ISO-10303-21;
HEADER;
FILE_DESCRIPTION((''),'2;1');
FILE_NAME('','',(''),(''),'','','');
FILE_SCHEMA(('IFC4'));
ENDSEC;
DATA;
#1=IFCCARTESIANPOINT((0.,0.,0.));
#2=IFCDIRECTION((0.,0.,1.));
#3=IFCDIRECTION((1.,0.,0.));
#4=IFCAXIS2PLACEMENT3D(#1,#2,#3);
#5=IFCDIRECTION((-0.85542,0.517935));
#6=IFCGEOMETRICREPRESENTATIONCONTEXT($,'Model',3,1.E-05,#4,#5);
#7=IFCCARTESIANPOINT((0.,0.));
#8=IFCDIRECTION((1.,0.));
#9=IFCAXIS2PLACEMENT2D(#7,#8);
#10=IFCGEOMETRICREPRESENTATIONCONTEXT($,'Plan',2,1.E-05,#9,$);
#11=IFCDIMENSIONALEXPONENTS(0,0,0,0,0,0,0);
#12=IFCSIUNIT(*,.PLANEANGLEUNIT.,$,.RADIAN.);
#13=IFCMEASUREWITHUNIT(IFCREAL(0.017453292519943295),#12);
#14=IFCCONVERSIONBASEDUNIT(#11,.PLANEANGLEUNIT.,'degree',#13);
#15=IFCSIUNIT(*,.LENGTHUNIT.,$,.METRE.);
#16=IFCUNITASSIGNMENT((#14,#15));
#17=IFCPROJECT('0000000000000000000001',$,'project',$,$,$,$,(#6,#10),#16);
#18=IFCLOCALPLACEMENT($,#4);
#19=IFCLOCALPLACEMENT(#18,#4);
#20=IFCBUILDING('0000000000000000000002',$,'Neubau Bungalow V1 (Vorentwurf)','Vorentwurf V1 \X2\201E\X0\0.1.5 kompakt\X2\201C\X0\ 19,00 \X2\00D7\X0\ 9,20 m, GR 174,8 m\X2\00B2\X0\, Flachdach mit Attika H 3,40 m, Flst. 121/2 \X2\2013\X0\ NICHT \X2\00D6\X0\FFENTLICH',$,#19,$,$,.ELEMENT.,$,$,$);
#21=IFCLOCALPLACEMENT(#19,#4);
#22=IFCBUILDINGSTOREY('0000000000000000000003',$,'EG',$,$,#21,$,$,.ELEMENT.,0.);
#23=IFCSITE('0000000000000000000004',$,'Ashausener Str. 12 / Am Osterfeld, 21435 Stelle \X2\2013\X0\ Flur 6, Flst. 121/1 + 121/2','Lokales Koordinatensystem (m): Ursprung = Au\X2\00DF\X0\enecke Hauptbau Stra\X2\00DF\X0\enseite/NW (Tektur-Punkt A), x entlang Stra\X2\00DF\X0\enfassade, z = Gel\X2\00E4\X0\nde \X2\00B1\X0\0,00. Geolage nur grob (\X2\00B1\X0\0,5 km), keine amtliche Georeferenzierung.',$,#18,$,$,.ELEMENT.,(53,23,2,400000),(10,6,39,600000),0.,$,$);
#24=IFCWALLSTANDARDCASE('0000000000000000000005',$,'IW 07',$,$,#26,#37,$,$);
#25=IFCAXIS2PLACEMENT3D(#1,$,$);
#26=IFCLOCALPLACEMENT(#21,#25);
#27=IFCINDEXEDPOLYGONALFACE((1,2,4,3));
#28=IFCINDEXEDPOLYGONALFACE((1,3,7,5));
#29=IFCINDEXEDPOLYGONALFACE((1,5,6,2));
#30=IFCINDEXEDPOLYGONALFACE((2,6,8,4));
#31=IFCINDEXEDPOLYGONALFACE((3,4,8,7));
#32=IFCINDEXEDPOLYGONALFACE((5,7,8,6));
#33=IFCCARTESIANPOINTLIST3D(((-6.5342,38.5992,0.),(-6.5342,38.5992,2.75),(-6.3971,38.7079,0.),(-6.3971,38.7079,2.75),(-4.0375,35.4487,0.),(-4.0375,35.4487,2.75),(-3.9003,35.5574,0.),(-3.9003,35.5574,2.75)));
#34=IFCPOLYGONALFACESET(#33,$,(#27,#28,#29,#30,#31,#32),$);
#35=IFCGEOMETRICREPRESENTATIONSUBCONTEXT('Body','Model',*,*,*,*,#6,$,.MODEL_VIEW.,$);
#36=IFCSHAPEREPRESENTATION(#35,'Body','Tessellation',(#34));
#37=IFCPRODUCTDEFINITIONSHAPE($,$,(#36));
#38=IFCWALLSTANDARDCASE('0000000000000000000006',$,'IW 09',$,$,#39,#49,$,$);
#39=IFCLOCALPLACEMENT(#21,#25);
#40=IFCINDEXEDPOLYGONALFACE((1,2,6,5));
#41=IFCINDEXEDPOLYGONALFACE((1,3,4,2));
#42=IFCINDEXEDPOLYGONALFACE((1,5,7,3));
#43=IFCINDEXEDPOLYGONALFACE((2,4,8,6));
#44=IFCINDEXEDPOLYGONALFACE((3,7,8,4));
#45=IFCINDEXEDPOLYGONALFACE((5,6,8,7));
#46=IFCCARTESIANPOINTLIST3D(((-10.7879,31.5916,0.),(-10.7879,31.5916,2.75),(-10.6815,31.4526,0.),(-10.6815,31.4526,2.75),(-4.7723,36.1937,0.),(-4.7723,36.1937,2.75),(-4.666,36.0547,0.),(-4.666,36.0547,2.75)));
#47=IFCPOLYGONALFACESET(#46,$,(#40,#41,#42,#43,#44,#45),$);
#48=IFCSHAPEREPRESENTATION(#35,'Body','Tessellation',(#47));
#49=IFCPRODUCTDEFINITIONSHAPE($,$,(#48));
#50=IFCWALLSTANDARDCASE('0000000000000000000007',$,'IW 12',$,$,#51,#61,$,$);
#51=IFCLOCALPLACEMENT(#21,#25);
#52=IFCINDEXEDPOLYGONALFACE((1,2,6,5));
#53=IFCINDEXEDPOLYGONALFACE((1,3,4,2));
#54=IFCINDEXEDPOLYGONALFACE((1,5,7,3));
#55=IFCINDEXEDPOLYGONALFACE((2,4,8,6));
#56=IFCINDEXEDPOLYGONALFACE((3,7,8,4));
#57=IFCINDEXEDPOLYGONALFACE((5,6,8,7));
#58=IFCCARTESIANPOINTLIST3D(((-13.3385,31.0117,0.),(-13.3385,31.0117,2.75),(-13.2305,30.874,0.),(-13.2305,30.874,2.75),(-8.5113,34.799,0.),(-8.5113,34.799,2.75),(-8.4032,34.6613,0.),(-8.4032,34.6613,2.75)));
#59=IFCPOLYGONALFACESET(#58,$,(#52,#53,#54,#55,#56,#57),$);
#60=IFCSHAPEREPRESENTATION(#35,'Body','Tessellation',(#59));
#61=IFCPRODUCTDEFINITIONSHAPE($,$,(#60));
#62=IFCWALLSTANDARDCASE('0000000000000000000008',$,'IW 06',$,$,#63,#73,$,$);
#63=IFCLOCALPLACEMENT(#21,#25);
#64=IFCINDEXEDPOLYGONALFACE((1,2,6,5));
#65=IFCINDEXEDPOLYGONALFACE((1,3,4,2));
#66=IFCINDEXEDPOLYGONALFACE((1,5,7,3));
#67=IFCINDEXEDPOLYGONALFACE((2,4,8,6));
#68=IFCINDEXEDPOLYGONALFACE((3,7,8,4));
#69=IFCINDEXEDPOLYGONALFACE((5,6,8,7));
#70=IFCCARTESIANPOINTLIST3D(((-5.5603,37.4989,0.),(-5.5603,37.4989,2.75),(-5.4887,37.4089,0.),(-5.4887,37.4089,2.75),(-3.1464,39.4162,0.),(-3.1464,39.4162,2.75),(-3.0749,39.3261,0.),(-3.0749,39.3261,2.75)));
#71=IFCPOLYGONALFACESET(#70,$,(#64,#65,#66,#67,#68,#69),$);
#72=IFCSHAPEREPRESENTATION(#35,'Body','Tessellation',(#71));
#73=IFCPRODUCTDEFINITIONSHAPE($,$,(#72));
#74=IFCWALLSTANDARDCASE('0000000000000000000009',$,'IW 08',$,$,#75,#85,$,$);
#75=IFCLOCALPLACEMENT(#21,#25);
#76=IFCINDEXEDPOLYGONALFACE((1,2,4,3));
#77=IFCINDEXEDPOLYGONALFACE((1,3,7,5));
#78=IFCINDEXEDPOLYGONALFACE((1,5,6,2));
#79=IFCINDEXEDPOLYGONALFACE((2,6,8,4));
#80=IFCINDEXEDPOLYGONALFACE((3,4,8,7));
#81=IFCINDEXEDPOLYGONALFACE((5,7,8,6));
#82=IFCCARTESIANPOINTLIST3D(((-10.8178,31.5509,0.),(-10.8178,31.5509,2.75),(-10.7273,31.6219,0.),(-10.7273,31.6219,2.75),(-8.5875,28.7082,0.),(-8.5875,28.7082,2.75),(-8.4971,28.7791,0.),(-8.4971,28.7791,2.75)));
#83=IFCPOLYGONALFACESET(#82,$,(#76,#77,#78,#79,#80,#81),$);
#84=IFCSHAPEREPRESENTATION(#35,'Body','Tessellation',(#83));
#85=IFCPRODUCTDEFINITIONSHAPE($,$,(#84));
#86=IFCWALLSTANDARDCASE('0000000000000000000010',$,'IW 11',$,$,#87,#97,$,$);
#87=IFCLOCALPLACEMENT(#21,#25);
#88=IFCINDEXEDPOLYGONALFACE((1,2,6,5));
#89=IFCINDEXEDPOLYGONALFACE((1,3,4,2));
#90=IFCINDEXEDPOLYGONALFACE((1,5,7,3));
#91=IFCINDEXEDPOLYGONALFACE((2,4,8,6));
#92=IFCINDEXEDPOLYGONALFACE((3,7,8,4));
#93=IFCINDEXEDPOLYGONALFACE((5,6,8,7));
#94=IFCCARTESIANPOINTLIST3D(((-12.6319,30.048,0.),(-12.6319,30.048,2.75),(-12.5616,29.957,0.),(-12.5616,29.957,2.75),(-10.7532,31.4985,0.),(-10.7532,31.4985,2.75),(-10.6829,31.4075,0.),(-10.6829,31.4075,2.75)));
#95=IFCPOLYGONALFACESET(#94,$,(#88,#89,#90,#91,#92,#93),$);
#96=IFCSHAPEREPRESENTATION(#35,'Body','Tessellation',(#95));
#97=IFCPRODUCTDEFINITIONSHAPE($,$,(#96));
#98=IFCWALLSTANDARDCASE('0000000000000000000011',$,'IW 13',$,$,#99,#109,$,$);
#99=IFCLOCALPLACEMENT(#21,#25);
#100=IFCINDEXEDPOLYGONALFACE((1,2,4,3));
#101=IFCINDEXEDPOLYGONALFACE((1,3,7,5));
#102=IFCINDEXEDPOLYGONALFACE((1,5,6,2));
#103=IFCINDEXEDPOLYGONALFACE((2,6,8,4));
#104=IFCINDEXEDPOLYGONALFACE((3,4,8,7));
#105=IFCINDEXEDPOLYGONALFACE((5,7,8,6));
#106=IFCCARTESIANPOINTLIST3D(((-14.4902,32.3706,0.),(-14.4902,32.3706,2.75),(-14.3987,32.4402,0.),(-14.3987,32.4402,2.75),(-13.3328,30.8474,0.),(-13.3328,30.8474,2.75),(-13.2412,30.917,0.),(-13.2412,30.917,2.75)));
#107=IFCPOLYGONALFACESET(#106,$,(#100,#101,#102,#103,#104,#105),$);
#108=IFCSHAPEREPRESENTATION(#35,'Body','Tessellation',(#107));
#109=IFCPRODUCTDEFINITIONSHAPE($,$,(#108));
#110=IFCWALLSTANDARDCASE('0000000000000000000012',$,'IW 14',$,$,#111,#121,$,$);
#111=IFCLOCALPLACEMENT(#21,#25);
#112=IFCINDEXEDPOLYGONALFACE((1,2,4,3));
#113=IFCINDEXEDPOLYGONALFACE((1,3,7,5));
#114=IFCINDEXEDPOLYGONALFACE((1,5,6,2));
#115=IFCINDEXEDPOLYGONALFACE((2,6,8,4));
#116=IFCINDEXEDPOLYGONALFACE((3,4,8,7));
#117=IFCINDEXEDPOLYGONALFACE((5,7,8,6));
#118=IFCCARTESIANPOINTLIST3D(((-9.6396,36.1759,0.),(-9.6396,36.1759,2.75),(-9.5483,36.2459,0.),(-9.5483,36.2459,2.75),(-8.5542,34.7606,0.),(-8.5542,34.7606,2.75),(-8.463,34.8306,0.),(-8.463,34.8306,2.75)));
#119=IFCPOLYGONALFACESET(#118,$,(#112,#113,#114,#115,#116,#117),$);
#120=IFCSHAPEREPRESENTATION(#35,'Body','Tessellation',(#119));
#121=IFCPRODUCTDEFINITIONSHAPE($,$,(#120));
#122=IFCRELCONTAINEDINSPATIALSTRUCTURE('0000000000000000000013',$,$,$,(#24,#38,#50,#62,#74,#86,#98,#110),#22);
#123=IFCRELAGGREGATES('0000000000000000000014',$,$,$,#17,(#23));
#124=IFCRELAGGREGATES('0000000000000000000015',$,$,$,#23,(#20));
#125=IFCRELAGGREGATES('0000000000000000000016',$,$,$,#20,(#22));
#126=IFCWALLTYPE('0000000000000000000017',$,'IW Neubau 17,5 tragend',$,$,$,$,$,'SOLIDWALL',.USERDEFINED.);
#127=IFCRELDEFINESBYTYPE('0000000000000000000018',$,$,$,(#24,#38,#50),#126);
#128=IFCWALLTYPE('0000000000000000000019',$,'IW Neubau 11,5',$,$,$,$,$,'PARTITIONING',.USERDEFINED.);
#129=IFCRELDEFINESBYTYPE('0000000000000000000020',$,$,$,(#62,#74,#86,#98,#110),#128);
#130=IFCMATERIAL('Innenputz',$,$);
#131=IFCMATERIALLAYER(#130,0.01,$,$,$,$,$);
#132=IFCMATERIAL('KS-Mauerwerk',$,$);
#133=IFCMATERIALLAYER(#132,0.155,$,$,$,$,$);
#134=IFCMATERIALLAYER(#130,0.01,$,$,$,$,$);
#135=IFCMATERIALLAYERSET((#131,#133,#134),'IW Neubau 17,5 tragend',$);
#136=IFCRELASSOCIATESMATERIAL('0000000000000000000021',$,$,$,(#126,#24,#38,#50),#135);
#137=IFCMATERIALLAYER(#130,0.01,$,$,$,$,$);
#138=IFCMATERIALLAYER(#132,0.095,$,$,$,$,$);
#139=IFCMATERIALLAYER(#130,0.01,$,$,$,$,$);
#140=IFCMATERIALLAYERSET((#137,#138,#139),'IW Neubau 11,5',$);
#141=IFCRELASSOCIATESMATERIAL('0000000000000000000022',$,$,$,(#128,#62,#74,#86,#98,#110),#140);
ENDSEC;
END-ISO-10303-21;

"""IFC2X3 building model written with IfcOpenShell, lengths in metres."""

from ifc_helpers import new_model, entity, si_unit, converted_unit, direction, frame, origin_with_axes, origin_2d_with_axis, place, context, subcontext, project, spatial, polyline, outline, extrude, material, layer, layer_set, layer_usage, type_object, element, save


model = new_model("IFC2X3")

# Units and contexts
model_context = context("Model", 3, precision=1e-05, world=origin_with_axes(), true_north=direction((-0.85542, 0.517935)))
plan_context = context("Plan", 2, precision=1e-05, world=origin_2d_with_axis())
body_context = subcontext(model_context, "Body", "Model", "MODEL_VIEW")
ifc_project = project(units=[converted_unit("PLANEANGLEUNIT", "degree", entity("IfcReal", 0.017453292519943295), si_unit("PLANEANGLEUNIT", "RADIAN"), dimensions=[0, 0, 0, 0, 0, 0, 0]), si_unit("LENGTHUNIT", "METRE")], contexts=[model_context, plan_context])

# Site, building, storey
site_placement = place(None, origin_with_axes())
site = spatial("IfcSite", under=ifc_project, at=site_placement, Name="Ashausener Str. 12 / Am Osterfeld, 21435 Stelle – Flur 6, Flst. 121/1 + 121/2", Description="Lokales Koordinatensystem (m): Ursprung = Außenecke Hauptbau Straßenseite/NW (Tektur-Punkt A), x entlang Straßenfassade, z = Gelände ±0,00. Geolage nur grob (±0,5 km), keine amtliche Georeferenzierung.", CompositionType="ELEMENT", RefLatitude=(53, 23, 2, 400000), RefLongitude=(10, 6, 39, 600000), RefElevation=0.0)
building_placement = place(site_placement, origin_with_axes())
building = spatial("IfcBuilding", under=site, at=building_placement, Name="Neubau Bungalow V1 (Vorentwurf)", Description="Vorentwurf V1 „0.1.5 kompakt“ 19,00 × 9,20 m, GR 174,8 m², Flachdach mit Attika H 3,40 m, Flst. 121/2 – NICHT ÖFFENTLICH", CompositionType="ELEMENT")
storey_placement = place(building_placement, origin_with_axes())
storey = spatial("IfcBuildingStorey", under=building, at=storey_placement, Name="EG", CompositionType="ELEMENT", Elevation=0.0)

# Shared definitions
ifc_material_1 = material(Name="KS-Mauerwerk")
ifc_material_2 = material(Name="Innenputz")

# Walls
ifc_layer_1 = layer(ifc_material_2, 0.01)
ifc_layer_2 = layer(ifc_material_1, 0.155)
ifc_layer_3 = layer(ifc_material_2, 0.01)
ifc_layer_set_1 = layer_set([ifc_layer_1, ifc_layer_2, ifc_layer_3], Name="IW Neubau 17,5 tragend")
ifc_layer_usage_1 = layer_usage(ifc_layer_set_1, "AXIS2", "POSITIVE", -0.0875)
wall_type_1 = type_object("IfcWallType", Name="IW Neubau 17,5 tragend", ElementType="SOLIDWALL", PredefinedType="USERDEFINED", material=ifc_layer_set_1)
wall_1_placement = place(storey_placement, frame((-6.4657, 38.6535, 0.0), z_axis=(0.0, 0.0, 1.0), x_axis=(0.621106, -0.783727, 0.0)))
element("IfcWallStandardCase", 1, at=wall_1_placement, inside=storey, type_object=wall_type_1, material=ifc_layer_usage_1, Name="IW 07", context=body_context, shape_type="SweptSolid", body=[
    extrude(outline(polyline([(0.0, 0.0), (0.0, 0.175), (4.0199, 0.175), (4.0199, 0.0), (0.0, 0.0)])), frame((0.0, -0.0875, 0.0), z_axis=(0.0, 0.0, 1.0), x_axis=(1.0, 0.0, 0.0)), (0.0, 0.0, 1.0), 2.75),
])
ifc_layer_usage_2 = layer_usage(ifc_layer_set_1, "AXIS2", "POSITIVE", -0.0875)
wall_2_placement = place(storey_placement, frame((-10.7347, 31.5221, 0.0), z_axis=(0.0, 0.0, 1.0), x_axis=(0.794233, 0.607613, 0.0)))
element("IfcWallStandardCase", 2, at=wall_2_placement, inside=storey, type_object=wall_type_1, material=ifc_layer_usage_2, Name="IW 09", context=body_context, shape_type="SweptSolid", body=[
    extrude(outline(polyline([(0.0, 0.0), (0.0, 0.175), (7.574, 0.175), (7.574, 0.0), (0.0, 0.0)])), frame((0.0, -0.0875, 0.0), z_axis=(0.0, 0.0, 1.0), x_axis=(1.0, 0.0, 0.0)), (0.0, 0.0, 1.0), 2.75),
])
ifc_layer_usage_3 = layer_usage(ifc_layer_set_1, "AXIS2", "POSITIVE", -0.0875)
wall_3_placement = place(storey_placement, frame((-13.2845, 30.9429, 0.0), z_axis=(0.0, 0.0, 1.0), x_axis=(0.786761, 0.617258, 0.0)))
element("IfcWallStandardCase", 3, at=wall_3_placement, inside=storey, type_object=wall_type_1, material=ifc_layer_usage_3, Name="IW 12", context=body_context, shape_type="SweptSolid", body=[
    extrude(outline(polyline([(0.0, 0.0), (0.0, 0.175), (6.1356, 0.175), (6.1356, 0.0), (0.0, 0.0)])), frame((0.0, -0.0875, 0.0), z_axis=(0.0, 0.0, 1.0), x_axis=(1.0, 0.0, 0.0)), (0.0, 0.0, 1.0), 2.75),
])
ifc_layer_4 = layer(ifc_material_2, 0.01)
ifc_layer_5 = layer(ifc_material_1, 0.095)
ifc_layer_6 = layer(ifc_material_2, 0.01)
ifc_layer_set_2 = layer_set([ifc_layer_4, ifc_layer_5, ifc_layer_6], Name="IW Neubau 11,5")
ifc_layer_usage_4 = layer_usage(ifc_layer_set_2, "AXIS2", "POSITIVE", -0.0575)
wall_type_2 = type_object("IfcWallType", Name="IW Neubau 11,5", ElementType="PARTITIONING", PredefinedType="USERDEFINED", material=ifc_layer_set_2)
wall_4_placement = place(storey_placement, frame((-5.5245, 37.4539, 0.0), z_axis=(0.0, 0.0, 1.0), x_axis=(0.783046, 0.621964, 0.0)))
element("IfcWallStandardCase", 4, at=wall_4_placement, inside=storey, type_object=wall_type_2, material=ifc_layer_usage_4, Name="IW 06", context=body_context, shape_type="SweptSolid", body=[
    extrude(outline(polyline([(0.0, 0.0), (0.0, 0.115), (3.0826, 0.115), (3.0826, 0.0), (0.0, 0.0)])), frame((0.0, -0.0575, 0.0), z_axis=(0.0, 0.0, 1.0), x_axis=(1.0, 0.0, 0.0)), (0.0, 0.0, 1.0), 2.75),
])
ifc_layer_usage_5 = layer_usage(ifc_layer_set_2, "AXIS2", "POSITIVE", -0.0575)
wall_5_placement = place(storey_placement, frame((-10.7726, 31.5864, 0.0), z_axis=(0.0, 0.0, 1.0), x_axis=(0.617258, -0.786761, 0.0)))
element("IfcWallStandardCase", 5, at=wall_5_placement, inside=storey, type_object=wall_type_2, material=ifc_layer_usage_5, Name="IW 08", context=body_context, shape_type="SweptSolid", body=[
    extrude(outline(polyline([(0.0, 0.0), (0.0, 0.115), (3.6132, 0.115), (3.6132, 0.0), (0.0, 0.0)])), frame((0.0, -0.0575, 0.0), z_axis=(0.0, 0.0, 1.0), x_axis=(1.0, 0.0, 0.0)), (0.0, 0.0, 1.0), 2.75),
])
ifc_layer_usage_6 = layer_usage(ifc_layer_set_2, "AXIS2", "POSITIVE", -0.0575)
wall_6_placement = place(storey_placement, frame((-12.5968, 30.0025, 0.0), z_axis=(0.0, 0.0, 1.0), x_axis=(0.791543, 0.611113, 0.0)))
element("IfcWallStandardCase", 6, at=wall_6_placement, inside=storey, type_object=wall_type_2, material=ifc_layer_usage_6, Name="IW 11", context=body_context, shape_type="SweptSolid", body=[
    extrude(outline(polyline([(0.0, 0.0), (0.0, 0.115), (2.3736, 0.115), (2.3736, 0.0), (0.0, 0.0)])), frame((0.0, -0.0575, 0.0), z_axis=(0.0, 0.0, 1.0), x_axis=(1.0, 0.0, 0.0)), (0.0, 0.0, 1.0), 2.75),
])
ifc_layer_usage_7 = layer_usage(ifc_layer_set_2, "AXIS2", "POSITIVE", -0.0575)
wall_7_placement = place(storey_placement, frame((-14.4445, 32.4054, 0.0), z_axis=(0.0, 0.0, 1.0), x_axis=(0.605034, -0.7962, 0.0)))
element("IfcWallStandardCase", 7, at=wall_7_placement, inside=storey, type_object=wall_type_2, material=ifc_layer_usage_7, Name="IW 13", context=body_context, shape_type="SweptSolid", body=[
    extrude(outline(polyline([(0.0, 0.0), (0.0, 0.115), (1.9131, 0.115), (1.9131, 0.0), (0.0, 0.0)])), frame((0.0, -0.0575, 0.0), z_axis=(0.0, 0.0, 1.0), x_axis=(1.0, 0.0, 0.0)), (0.0, 0.0, 1.0), 2.75),
])
ifc_layer_usage_8 = layer_usage(ifc_layer_set_2, "AXIS2", "POSITIVE", -0.0575)
wall_8_placement = place(storey_placement, frame((-9.594, 36.2109, 0.0), z_axis=(0.0, 0.0, 1.0), x_axis=(0.608532, -0.793529, 0.0)))
element("IfcWallStandardCase", 8, at=wall_8_placement, inside=storey, type_object=wall_type_2, material=ifc_layer_usage_8, Name="IW 14", context=body_context, shape_type="SweptSolid", body=[
    extrude(outline(polyline([(0.0, 0.0), (0.0, 0.115), (1.7836, 0.115), (1.7836, 0.0), (0.0, 0.0)])), frame((0.0, -0.0575, 0.0), z_axis=(0.0, 0.0, 1.0), x_axis=(1.0, 0.0, 0.0)), (0.0, 0.0, 1.0), 2.75),
])

save(model, "model.ifc")
